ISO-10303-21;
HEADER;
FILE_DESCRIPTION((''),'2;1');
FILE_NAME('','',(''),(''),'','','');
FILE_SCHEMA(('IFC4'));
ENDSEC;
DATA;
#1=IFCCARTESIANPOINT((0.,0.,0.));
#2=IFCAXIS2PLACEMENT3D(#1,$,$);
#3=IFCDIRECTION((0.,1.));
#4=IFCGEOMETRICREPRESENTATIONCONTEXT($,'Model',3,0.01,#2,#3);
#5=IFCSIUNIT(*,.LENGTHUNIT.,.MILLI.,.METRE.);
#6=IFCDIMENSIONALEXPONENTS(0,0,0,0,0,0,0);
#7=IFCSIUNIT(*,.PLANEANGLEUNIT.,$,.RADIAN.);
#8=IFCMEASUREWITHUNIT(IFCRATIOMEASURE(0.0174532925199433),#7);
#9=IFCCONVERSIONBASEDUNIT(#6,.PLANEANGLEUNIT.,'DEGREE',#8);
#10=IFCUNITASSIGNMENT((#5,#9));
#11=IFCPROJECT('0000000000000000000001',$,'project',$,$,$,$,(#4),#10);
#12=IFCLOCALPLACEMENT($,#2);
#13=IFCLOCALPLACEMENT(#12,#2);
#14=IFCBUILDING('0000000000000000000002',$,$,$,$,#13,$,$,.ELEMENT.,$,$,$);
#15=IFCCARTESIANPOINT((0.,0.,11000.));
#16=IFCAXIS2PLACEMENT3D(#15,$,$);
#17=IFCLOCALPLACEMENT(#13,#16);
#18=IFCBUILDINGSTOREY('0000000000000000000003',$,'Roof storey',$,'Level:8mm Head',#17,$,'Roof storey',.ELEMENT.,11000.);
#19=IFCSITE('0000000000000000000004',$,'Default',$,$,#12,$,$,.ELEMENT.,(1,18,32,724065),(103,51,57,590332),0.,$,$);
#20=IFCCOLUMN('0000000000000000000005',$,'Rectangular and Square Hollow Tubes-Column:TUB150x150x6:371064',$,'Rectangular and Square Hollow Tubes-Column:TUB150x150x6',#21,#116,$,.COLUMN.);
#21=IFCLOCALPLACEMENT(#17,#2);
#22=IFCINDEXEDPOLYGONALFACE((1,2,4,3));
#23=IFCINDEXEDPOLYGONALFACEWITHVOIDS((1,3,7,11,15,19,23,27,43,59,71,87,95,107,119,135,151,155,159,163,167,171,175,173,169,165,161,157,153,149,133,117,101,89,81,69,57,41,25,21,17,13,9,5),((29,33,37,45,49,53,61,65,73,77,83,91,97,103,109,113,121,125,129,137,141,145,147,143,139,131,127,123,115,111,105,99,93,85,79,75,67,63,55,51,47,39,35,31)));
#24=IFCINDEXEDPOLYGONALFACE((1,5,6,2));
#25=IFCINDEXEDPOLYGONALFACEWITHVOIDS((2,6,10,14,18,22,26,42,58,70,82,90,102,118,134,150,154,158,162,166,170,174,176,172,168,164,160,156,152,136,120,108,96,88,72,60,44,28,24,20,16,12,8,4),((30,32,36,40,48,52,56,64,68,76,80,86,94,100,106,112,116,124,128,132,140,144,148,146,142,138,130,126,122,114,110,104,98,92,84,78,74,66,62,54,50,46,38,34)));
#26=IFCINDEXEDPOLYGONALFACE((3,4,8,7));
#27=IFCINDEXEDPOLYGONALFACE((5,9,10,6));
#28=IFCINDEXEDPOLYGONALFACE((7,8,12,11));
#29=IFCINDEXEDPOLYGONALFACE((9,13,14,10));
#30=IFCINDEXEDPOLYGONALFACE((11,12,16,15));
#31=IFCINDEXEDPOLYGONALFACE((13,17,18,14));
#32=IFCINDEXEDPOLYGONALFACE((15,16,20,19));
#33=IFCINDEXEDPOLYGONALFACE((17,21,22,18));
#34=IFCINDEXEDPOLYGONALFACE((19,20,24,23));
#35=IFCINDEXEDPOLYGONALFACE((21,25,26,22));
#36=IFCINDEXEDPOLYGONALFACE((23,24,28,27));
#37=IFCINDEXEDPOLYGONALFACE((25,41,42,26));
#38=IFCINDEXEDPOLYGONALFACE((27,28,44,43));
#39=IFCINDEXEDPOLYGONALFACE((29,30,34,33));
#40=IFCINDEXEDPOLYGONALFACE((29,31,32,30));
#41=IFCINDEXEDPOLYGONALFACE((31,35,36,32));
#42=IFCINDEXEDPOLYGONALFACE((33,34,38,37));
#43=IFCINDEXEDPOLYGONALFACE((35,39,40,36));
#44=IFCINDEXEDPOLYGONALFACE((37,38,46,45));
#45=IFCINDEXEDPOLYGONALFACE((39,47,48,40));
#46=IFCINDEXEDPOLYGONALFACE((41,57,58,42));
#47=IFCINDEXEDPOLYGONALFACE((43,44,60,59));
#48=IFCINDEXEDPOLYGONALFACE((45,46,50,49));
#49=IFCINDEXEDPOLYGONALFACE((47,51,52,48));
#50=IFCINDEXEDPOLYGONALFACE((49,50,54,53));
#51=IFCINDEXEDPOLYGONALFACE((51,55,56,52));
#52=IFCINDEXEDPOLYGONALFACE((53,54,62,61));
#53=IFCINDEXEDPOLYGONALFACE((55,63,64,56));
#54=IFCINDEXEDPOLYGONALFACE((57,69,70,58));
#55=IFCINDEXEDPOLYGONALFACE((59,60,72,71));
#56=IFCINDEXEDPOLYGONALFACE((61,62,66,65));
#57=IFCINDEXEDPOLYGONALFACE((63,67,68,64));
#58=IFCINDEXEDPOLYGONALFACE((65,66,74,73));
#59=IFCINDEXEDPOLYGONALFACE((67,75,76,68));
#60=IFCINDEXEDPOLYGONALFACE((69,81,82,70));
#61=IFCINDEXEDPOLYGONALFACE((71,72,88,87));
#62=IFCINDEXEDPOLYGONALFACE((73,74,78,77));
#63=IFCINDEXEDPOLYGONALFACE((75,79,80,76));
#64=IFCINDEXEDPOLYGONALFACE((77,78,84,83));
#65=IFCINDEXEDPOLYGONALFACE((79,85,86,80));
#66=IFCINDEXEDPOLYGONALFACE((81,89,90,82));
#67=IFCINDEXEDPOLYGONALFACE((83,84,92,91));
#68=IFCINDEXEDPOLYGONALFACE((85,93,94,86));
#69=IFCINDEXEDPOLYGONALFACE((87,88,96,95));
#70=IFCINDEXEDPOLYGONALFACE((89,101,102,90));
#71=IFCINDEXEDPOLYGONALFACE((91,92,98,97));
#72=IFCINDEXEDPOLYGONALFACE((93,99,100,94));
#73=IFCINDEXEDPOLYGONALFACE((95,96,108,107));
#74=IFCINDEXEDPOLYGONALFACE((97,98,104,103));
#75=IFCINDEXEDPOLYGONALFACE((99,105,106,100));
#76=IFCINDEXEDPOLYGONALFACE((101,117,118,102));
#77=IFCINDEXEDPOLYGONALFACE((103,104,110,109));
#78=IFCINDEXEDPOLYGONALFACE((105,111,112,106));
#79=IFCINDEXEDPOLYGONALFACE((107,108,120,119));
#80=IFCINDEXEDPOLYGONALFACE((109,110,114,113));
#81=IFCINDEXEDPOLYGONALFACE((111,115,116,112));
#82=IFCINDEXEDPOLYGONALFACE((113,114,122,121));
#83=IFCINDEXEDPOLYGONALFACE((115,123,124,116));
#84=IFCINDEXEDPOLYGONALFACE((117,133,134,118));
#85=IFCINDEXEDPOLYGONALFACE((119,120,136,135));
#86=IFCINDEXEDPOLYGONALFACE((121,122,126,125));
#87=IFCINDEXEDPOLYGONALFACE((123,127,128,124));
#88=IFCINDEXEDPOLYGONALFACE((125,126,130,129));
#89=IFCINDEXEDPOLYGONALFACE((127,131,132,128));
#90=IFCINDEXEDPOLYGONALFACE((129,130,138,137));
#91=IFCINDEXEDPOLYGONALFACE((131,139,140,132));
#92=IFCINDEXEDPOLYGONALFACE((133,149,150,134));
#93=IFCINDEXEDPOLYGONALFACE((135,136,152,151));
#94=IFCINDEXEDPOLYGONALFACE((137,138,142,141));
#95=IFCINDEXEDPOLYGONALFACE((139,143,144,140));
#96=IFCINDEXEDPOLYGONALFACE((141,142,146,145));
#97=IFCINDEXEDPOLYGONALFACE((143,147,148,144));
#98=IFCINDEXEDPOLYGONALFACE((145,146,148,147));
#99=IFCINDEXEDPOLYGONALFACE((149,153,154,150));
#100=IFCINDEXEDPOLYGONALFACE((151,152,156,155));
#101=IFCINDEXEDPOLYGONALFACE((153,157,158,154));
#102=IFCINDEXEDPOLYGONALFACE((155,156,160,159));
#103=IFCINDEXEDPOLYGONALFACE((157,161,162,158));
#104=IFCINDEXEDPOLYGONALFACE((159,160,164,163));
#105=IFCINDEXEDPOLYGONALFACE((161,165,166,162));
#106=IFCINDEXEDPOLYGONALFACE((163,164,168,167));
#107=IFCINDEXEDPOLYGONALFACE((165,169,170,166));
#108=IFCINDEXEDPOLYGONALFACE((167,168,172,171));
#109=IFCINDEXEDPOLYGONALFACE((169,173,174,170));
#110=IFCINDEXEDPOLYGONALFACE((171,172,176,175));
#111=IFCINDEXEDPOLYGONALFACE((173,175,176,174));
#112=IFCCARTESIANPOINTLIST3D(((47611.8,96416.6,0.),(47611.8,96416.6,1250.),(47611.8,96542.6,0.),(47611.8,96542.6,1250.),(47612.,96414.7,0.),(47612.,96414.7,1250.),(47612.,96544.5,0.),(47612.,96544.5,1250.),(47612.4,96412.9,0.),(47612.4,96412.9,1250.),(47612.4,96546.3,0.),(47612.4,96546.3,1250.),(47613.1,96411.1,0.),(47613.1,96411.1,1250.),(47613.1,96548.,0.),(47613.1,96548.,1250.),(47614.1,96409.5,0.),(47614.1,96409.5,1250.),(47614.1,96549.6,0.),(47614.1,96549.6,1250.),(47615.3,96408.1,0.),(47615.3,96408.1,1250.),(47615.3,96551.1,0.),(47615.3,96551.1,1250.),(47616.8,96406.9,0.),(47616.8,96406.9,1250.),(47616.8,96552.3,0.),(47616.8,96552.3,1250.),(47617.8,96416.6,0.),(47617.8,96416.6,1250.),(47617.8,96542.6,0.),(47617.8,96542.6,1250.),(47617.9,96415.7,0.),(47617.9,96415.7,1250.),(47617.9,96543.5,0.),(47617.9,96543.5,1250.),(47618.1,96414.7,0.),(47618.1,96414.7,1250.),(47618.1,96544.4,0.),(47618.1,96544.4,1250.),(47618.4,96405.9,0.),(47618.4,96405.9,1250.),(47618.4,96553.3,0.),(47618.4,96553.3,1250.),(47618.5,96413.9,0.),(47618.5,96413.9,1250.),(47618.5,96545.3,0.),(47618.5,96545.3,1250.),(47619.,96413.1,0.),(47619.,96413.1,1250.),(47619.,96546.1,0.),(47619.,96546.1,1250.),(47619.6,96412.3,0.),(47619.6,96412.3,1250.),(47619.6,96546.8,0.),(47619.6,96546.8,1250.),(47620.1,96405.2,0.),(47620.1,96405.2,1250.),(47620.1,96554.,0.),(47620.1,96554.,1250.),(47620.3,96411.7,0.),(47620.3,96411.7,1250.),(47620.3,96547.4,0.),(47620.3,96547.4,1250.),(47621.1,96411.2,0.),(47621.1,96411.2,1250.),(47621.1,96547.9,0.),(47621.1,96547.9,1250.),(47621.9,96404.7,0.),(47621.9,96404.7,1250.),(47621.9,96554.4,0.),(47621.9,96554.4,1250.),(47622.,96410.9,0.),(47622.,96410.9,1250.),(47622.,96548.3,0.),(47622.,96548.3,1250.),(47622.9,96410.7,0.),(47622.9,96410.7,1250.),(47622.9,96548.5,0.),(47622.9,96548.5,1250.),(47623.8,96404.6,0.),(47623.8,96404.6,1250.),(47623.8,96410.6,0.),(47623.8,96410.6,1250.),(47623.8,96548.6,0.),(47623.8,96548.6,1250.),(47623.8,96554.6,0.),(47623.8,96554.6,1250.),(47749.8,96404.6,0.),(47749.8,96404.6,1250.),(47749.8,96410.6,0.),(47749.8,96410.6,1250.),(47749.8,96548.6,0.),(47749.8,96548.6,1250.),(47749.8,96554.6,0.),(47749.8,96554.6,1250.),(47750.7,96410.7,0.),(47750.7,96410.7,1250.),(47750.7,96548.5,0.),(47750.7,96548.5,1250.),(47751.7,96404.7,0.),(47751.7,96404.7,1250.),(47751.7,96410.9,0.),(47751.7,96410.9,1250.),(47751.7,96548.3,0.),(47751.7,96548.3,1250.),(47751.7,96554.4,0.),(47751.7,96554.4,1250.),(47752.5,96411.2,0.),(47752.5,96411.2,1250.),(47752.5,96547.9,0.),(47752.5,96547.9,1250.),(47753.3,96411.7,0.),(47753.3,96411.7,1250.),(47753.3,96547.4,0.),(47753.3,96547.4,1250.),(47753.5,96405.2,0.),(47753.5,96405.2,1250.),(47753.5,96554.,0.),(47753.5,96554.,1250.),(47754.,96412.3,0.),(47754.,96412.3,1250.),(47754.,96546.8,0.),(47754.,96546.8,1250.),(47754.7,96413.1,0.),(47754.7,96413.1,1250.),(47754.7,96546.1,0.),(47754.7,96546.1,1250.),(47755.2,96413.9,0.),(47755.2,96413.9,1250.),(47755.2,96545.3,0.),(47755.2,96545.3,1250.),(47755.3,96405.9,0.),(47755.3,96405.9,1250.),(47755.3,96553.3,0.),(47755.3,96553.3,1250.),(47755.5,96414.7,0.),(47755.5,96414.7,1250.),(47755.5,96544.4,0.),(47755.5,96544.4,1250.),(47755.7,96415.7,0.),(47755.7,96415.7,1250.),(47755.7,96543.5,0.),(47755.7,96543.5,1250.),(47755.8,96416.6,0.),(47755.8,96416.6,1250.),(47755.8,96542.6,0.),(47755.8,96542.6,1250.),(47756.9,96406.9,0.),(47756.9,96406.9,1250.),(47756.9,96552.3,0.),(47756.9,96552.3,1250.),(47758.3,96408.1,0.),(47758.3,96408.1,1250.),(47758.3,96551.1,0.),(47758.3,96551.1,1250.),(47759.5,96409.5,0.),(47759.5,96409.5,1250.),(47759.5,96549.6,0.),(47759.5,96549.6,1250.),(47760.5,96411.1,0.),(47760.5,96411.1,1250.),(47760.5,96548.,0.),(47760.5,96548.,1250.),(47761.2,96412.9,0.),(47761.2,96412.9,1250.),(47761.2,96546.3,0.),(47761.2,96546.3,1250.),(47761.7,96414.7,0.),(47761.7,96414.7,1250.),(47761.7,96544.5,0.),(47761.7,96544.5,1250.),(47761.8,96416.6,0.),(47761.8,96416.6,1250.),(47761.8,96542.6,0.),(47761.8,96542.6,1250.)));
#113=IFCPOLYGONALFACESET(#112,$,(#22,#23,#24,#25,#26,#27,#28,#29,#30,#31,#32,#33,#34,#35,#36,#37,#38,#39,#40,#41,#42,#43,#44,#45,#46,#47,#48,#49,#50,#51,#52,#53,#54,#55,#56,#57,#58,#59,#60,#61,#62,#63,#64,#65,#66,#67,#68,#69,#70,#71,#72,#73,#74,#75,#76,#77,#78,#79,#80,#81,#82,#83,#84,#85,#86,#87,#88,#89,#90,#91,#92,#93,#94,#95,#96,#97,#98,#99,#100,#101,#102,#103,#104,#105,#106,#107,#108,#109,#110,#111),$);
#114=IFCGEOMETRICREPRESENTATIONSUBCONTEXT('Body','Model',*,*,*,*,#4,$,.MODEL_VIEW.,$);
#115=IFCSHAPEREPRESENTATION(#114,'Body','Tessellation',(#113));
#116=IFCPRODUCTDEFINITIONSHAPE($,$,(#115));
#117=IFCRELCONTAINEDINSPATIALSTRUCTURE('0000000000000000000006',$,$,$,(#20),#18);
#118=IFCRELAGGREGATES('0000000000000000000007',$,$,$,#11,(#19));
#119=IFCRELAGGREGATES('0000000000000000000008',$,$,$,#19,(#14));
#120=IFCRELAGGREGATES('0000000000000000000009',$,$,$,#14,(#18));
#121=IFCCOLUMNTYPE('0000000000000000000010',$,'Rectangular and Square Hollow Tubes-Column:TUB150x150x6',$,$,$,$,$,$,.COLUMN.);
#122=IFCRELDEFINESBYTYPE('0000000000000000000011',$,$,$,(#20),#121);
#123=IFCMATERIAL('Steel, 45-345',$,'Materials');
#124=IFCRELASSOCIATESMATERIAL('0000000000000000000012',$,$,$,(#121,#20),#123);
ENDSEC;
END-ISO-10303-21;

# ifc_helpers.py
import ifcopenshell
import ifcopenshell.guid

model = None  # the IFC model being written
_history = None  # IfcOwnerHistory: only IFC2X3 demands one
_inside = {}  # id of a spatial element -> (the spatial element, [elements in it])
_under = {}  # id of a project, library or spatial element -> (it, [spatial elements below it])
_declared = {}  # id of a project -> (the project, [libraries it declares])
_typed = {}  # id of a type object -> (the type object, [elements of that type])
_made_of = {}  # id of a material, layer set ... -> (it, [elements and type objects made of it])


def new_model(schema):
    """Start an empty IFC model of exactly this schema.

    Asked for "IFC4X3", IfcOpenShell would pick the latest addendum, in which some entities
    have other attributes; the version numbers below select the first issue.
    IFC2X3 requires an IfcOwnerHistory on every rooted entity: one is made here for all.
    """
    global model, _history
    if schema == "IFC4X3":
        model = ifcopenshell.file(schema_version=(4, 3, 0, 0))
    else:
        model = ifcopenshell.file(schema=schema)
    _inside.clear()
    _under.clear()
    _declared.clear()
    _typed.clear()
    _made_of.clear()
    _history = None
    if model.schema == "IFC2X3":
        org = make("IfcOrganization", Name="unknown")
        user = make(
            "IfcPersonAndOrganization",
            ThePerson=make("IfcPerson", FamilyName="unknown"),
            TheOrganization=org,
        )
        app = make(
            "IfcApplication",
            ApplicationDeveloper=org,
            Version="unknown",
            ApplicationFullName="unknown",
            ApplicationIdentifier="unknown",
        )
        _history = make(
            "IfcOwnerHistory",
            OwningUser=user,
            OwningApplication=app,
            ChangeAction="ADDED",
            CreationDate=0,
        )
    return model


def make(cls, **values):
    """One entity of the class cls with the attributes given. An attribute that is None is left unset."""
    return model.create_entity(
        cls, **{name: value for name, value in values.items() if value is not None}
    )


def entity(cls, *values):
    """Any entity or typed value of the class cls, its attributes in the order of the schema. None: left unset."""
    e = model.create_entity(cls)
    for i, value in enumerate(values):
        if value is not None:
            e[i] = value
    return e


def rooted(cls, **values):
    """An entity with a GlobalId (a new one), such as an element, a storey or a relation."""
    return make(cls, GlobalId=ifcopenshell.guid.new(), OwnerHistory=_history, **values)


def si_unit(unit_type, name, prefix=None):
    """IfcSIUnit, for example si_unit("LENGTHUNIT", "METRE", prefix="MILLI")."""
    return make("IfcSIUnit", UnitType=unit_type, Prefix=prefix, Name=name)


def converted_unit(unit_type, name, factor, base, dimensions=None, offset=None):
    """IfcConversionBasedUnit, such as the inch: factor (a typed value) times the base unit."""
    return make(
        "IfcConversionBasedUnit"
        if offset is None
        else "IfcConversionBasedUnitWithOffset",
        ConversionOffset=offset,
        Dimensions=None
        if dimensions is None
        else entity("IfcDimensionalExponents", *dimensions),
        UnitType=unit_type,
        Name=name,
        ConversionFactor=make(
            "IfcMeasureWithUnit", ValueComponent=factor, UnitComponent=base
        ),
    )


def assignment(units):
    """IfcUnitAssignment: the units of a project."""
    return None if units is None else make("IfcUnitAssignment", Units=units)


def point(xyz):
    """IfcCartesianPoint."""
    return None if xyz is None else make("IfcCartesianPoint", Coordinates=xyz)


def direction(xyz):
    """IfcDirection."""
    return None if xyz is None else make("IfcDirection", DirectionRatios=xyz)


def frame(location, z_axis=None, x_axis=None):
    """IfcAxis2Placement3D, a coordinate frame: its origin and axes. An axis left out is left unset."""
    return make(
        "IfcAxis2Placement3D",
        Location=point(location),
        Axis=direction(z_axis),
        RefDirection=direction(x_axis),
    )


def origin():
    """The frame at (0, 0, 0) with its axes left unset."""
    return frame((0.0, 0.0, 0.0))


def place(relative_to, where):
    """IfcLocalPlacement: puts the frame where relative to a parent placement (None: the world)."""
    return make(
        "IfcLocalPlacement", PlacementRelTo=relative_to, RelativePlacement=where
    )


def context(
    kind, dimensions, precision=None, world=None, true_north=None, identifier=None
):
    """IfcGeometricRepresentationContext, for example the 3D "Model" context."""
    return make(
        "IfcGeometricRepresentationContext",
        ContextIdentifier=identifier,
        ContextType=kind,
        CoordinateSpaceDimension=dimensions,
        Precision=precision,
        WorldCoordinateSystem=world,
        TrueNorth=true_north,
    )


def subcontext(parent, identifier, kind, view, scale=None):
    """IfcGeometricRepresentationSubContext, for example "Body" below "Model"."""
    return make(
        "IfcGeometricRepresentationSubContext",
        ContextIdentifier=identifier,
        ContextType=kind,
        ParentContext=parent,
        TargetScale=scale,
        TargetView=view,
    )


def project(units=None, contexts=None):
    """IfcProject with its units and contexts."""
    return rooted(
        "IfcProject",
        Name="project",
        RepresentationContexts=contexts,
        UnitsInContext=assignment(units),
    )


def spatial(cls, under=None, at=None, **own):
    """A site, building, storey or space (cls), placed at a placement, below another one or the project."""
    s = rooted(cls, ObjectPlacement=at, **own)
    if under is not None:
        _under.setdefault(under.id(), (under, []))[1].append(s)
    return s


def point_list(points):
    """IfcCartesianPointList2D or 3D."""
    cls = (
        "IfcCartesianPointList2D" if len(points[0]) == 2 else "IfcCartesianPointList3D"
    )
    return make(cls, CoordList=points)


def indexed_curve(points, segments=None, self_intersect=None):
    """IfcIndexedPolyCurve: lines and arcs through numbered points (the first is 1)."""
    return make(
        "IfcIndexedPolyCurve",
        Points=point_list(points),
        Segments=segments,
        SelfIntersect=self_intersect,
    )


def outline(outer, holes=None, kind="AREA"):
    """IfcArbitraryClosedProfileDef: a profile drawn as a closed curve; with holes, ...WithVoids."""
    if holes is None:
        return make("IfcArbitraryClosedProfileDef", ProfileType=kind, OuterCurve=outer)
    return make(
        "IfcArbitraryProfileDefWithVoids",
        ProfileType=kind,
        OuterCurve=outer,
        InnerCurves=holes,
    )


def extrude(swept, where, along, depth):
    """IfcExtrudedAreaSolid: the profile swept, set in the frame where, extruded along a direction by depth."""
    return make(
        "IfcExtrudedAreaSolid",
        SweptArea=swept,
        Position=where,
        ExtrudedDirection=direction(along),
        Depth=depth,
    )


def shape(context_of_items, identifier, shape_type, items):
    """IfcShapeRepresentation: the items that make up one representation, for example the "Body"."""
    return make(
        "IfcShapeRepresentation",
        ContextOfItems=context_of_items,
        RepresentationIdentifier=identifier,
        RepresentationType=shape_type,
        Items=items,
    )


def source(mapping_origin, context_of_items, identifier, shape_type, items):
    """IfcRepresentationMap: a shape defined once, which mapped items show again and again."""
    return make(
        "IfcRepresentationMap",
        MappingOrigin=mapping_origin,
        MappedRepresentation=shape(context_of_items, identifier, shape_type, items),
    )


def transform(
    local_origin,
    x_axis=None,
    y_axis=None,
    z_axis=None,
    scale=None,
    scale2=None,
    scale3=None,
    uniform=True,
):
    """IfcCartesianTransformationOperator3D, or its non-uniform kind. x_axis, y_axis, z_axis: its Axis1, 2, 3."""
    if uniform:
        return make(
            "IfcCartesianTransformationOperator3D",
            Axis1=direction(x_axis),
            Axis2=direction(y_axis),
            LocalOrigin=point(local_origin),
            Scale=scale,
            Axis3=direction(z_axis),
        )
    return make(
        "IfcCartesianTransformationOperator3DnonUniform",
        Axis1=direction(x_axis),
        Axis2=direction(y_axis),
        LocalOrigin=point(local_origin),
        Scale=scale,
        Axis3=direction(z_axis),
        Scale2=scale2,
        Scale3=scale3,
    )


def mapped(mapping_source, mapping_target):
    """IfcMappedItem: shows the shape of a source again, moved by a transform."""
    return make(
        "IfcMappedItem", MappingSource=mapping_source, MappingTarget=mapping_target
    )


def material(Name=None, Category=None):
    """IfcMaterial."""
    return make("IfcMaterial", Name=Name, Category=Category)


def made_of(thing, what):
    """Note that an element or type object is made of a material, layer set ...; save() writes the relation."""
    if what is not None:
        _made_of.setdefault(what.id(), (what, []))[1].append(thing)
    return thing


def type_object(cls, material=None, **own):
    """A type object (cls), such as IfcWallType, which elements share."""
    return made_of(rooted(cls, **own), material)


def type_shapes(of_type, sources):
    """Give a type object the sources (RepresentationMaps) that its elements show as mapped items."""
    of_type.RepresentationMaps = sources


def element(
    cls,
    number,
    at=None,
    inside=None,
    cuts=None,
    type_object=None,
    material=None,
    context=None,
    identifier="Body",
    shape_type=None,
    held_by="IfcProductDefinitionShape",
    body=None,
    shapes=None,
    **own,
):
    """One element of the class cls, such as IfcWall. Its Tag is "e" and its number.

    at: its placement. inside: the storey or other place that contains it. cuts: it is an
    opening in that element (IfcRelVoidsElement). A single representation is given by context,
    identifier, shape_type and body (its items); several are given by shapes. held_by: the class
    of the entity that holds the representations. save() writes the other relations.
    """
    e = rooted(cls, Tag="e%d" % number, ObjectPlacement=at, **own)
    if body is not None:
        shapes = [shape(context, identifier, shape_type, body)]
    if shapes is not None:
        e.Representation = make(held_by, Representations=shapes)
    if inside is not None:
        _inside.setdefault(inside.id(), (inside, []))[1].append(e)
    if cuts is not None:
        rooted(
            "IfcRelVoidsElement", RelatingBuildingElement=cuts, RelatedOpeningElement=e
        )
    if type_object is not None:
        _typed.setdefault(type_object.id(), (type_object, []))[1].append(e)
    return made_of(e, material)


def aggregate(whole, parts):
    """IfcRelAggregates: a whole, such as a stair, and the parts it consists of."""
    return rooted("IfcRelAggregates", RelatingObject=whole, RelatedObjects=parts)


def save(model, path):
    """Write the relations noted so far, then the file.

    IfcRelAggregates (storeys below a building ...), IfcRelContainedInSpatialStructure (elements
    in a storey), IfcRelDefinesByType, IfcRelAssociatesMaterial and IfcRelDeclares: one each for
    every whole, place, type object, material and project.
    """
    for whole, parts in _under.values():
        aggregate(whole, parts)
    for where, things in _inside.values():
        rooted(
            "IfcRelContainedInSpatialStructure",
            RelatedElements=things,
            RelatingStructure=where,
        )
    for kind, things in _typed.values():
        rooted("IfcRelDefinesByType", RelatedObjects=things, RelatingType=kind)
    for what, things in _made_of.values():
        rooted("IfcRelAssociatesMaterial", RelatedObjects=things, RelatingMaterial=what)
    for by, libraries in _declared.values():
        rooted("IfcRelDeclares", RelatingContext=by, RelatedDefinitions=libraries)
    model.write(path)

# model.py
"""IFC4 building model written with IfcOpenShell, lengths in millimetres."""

from ifc_helpers import new_model, entity, si_unit, converted_unit, direction, frame, origin, place, context, subcontext, project, spatial, indexed_curve, outline, extrude, source, transform, mapped, material, type_object, type_shapes, element, save


model = new_model("IFC4")

# Units and contexts
model_context = context("Model", 3, precision=0.01, world=origin(), true_north=direction((0.0, 1.0)))
body_context = subcontext(model_context, "Body", "Model", "MODEL_VIEW")
ifc_project = project(units=[si_unit("LENGTHUNIT", "METRE", prefix="MILLI"), converted_unit("PLANEANGLEUNIT", "DEGREE", entity("IfcRatioMeasure", 0.0174532925199433), si_unit("PLANEANGLEUNIT", "RADIAN"), dimensions=[0, 0, 0, 0, 0, 0, 0])], contexts=[model_context])

# Site, building, storey
site_placement = place(None, origin())
site = spatial("IfcSite", under=ifc_project, at=site_placement, Name="Default", CompositionType="ELEMENT", RefLatitude=(1, 18, 32, 724065), RefLongitude=(103, 51, 57, 590332), RefElevation=0.0)
building_placement = place(site_placement, origin())
building = spatial("IfcBuilding", under=site, at=building_placement, CompositionType="ELEMENT")
storey_placement = place(building_placement, frame((0.0, 0.0, 11000.0)))
storey = spatial("IfcBuildingStorey", under=building, at=storey_placement, Name="Roof storey", ObjectType="Level:8mm Head", LongName="Roof storey", CompositionType="ELEMENT", Elevation=11000.0)

# Column
ifc_material = material(Name="Steel, 45-345", Category="Materials")
column_type = type_object("IfcColumnType", Name="Rectangular and Square Hollow Tubes-Column:TUB150x150x6", PredefinedType="COLUMN", material=ifc_material)
shared_shape_1 = source(origin(), body_context, "Body", "SweptSolid", [
    extrude(outline(indexed_curve([(-63.0, -75.0), (63.0, -75.0), (64.9, -74.9), (66.7, -74.4), (68.4, -73.7), (70.1, -72.7), (71.5, -71.5), (72.7, -70.1), (73.7, -68.4), (74.4, -66.7), (74.9, -64.9), (75.0, -63.0), (75.0, 63.0), (74.9, 64.9), (74.4, 66.7), (73.7, 68.4), (72.7, 70.1), (71.5, 71.5), (70.1, 72.7), (68.4, 73.7), (66.7, 74.4), (64.9, 74.9), (63.0, 75.0), (-63.0, 75.0), (-64.9, 74.9), (-66.7, 74.4), (-68.4, 73.7), (-70.1, 72.7), (-71.5, 71.5), (-72.7, 70.1), (-73.7, 68.4), (-74.4, 66.7), (-74.9, 64.9), (-75.0, 63.0), (-75.0, -63.0), (-74.9, -64.9), (-74.4, -66.7), (-73.7, -68.4), (-72.7, -70.1), (-71.5, -71.5), (-70.1, -72.7), (-68.4, -73.7), (-66.7, -74.4), (-64.9, -74.9), (-63.0, -75.0)], self_intersect=False), holes=[indexed_curve([(-63.0, -69.0), (-63.9, -68.9), (-64.9, -68.7), (-65.7, -68.3), (-66.5, -67.9), (-67.2, -67.2), (-67.9, -66.5), (-68.3, -65.7), (-68.7, -64.9), (-68.9, -63.9), (-69.0, -63.0), (-69.0, 63.0), (-68.9, 63.9), (-68.7, 64.9), (-68.3, 65.7), (-67.9, 66.5), (-67.2, 67.2), (-66.5, 67.9), (-65.7, 68.3), (-64.9, 68.7), (-63.9, 68.9), (-63.0, 69.0), (63.0, 69.0), (63.9, 68.9), (64.9, 68.7), (65.7, 68.3), (66.5, 67.9), (67.2, 67.2), (67.9, 66.5), (68.3, 65.7), (68.7, 64.9), (68.9, 63.9), (69.0, 63.0), (69.0, -63.0), (68.9, -63.9), (68.7, -64.9), (68.3, -65.7), (67.9, -66.5), (67.2, -67.2), (66.5, -67.9), (65.7, -68.3), (64.9, -68.7), (63.9, -68.9), (63.0, -69.0), (-63.0, -69.0)], self_intersect=False)]), frame((0.0, 0.0, 11000.0), z_axis=(0.0, 0.0, 1.0), x_axis=(-1.0, 0.0, 0.0)), (0.0, 0.0, 1.0), 1250.0),
])
type_shapes(column_type, [shared_shape_1])
for number, where, name in (
    (1, (47686.8, 96479.6, -11000.0), "Rectangular and Square Hollow Tubes-Column:TUB150x150x6:371064"),
):
    element("IfcColumn", number, at=place(storey_placement, frame(where)), inside=storey, type_object=column_type, material=ifc_material, Name=name, ObjectType="Rectangular and Square Hollow Tubes-Column:TUB150x150x6", PredefinedType="COLUMN", context=body_context, shape_type="MappedRepresentation", body=[
        mapped(shared_shape_1, transform((0.0, 0.0, 0.0), scale=1.0)),
    ])

save(model, "model.ifc")
